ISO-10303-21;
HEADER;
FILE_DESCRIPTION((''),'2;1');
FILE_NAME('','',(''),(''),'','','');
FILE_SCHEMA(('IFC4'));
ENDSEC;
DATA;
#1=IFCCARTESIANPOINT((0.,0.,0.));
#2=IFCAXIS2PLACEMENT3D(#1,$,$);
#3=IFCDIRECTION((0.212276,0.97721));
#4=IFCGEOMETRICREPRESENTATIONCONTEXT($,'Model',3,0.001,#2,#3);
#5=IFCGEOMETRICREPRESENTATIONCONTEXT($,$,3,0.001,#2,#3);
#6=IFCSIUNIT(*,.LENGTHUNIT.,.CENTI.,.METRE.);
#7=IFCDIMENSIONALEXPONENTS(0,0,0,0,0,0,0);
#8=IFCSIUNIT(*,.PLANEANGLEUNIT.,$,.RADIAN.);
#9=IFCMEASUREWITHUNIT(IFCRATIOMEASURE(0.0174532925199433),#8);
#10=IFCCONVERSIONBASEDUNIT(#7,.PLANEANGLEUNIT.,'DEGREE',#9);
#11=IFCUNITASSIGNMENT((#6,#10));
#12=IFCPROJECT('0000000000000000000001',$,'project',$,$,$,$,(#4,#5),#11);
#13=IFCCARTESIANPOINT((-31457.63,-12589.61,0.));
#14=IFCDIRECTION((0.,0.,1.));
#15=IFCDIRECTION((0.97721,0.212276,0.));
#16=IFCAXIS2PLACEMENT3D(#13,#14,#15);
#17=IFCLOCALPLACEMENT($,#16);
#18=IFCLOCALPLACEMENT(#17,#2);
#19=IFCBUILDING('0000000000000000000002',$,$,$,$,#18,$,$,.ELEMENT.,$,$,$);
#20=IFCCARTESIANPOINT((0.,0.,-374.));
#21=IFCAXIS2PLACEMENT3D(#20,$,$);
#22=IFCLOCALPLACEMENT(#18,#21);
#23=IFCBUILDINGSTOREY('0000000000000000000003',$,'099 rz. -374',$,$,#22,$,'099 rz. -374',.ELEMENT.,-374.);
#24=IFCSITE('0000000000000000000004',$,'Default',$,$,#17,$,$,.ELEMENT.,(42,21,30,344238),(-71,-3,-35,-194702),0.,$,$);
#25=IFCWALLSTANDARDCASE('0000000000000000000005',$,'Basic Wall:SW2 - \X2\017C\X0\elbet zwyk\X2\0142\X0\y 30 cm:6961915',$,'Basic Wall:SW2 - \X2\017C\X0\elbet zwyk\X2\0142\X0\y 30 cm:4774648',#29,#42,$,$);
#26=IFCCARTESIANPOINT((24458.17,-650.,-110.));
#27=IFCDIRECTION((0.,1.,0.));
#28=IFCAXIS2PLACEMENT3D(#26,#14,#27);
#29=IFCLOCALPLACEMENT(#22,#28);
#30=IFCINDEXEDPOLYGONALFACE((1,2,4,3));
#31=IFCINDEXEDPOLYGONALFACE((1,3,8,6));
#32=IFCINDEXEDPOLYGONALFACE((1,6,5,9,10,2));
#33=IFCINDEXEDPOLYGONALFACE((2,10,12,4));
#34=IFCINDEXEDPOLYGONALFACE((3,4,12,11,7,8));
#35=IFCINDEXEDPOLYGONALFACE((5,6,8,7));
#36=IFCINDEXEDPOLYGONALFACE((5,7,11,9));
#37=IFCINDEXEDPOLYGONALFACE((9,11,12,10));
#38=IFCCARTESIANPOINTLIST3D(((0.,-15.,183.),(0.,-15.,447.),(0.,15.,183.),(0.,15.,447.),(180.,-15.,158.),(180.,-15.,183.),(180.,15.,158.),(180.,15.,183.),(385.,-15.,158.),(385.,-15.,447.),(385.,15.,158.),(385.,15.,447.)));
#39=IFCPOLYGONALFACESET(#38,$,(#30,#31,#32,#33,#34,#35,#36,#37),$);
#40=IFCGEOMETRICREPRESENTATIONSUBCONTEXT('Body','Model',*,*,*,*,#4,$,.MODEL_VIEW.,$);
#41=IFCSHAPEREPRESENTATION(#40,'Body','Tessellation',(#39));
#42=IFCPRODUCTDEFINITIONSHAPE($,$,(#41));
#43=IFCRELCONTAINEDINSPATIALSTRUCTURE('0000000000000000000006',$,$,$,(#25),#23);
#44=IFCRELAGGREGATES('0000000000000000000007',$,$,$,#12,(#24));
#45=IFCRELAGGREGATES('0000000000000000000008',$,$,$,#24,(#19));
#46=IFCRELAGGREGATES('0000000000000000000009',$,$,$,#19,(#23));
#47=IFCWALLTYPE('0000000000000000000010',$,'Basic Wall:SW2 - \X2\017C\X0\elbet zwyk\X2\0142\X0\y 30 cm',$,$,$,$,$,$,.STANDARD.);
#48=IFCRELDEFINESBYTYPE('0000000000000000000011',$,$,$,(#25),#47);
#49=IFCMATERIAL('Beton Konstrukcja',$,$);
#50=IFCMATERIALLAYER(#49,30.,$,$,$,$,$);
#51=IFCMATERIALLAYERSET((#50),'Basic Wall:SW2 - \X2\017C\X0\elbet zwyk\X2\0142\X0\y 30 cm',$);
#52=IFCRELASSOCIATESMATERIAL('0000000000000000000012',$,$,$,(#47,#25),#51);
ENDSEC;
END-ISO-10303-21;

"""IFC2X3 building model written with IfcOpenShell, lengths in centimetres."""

from ifc_helpers import new_model, entity, si_unit, converted_unit, direction, frame, frame_2d, origin, origin_2d_with_axis, place, context, subcontext, project, spatial, polyline, rectangle, extrude, clip, bounded_halfspace, material, layer, layer_set, layer_usage, type_object, element, save


model = new_model("IFC2X3")

# Units and contexts
model_context = context("Model", 3, precision=0.001, world=origin(), true_north=direction((0.212276, 0.97721)))
context_of_model = context(None, 3, precision=0.001, world=origin(), true_north=direction((0.212276, 0.97721)))
body_context = subcontext(model_context, "Body", "Model", "MODEL_VIEW")
ifc_project = project(units=[si_unit("LENGTHUNIT", "METRE", prefix="CENTI"), converted_unit("PLANEANGLEUNIT", "DEGREE", entity("IfcRatioMeasure", 0.0174532925199433), si_unit("PLANEANGLEUNIT", "RADIAN"), dimensions=[0, 0, 0, 0, 0, 0, 0])], contexts=[model_context, context_of_model])

# Site, building, storey
site_placement = place(None, frame((-31457.63, -12589.61, 0.0), z_axis=(0.0, 0.0, 1.0), x_axis=(0.97721, 0.212276, 0.0)))
site = spatial("IfcSite", under=ifc_project, at=site_placement, Name="Default", CompositionType="ELEMENT", RefLatitude=(42, 21, 30, 344238), RefLongitude=(-71, -3, -35, -194702), RefElevation=0.0)
building_placement = place(site_placement, origin())
building = spatial("IfcBuilding", under=site, at=building_placement, CompositionType="ELEMENT")
storey_placement = place(building_placement, frame((0.0, 0.0, -374.0)))
storey = spatial("IfcBuildingStorey", under=building, at=storey_placement, Name="099 rz. -374", LongName="099 rz. -374", CompositionType="ELEMENT", Elevation=-374.0)

# Shared definitions
ifc_material_1 = material(Name="Beton Konstrukcja")

# Wall, openings
ifc_layer_1 = layer(ifc_material_1, 30.0)
ifc_layer_set_1 = layer_set([ifc_layer_1], Name="Basic Wall:SW2 - żelbet zwykły 30 cm")
ifc_layer_usage_1 = layer_usage(ifc_layer_set_1, "AXIS2", "POSITIVE", -15.0)
wall_type_1 = type_object("IfcWallType", Name="Basic Wall:SW2 - żelbet zwykły 30 cm", PredefinedType="STANDARD", material=ifc_layer_set_1)
wall_1_placement = place(storey_placement, frame((24458.17, -650.0, -110.0), z_axis=(0.0, 0.0, 1.0), x_axis=(0.0, 1.0, 0.0)))
wall_1 = element("IfcWallStandardCase", 1, at=wall_1_placement, inside=storey, type_object=wall_type_1, material=ifc_layer_usage_1, Name="Basic Wall:SW2 - żelbet zwykły 30 cm:6961915", ObjectType="Basic Wall:SW2 - żelbet zwykły 30 cm:4774648", context=body_context, shape_type="Clipping", body=[
    clip(clip(clip(extrude(rectangle(XDim=385.0, YDim=30.0, at=frame_2d((192.5, 0.0), x_axis=(-1.0, 0.0))), origin(), (0.0, 0.0, 1.0), 447.0), bounded_halfspace(frame((180.0, -15.0, 183.0), z_axis=(0.0, 0.0, 1.0), x_axis=(-1.0, 0.0, 0.0)), True, frame((180.0, -15.0, 183.0)), polyline([(0.0, 0.0), (0.0, 30.0), (-20.0, 30.0), (-180.0, 30.0), (-180.0, 0.0), (0.0, 0.0)]))), bounded_halfspace(frame((0.0, -15.0, 447.0), z_axis=(0.0, 0.0, -1.0), x_axis=(0.0, -1.0, 0.0)), True, frame((0.0, -15.0, 447.0)), polyline([(0.0, 0.0), (385.0, 0.0), (385.0, 30.0), (180.0, 30.0), (0.0, 30.0), (0.0, 0.0)]))), bounded_halfspace(frame((385.0, -15.0, 158.0), z_axis=(0.0, 0.0, 1.0), x_axis=(0.0, 1.0, 0.0)), True, frame((385.0, -15.0, 158.0), z_axis=(0.0, 0.0, 1.0), x_axis=(0.0, 1.0, 0.0)), polyline([(0.0, 0.0), (30.0, 0.0), (30.0, 205.0), (0.0, 205.0), (0.0, 0.0)]))),
])
opening_1_placement = place(wall_1_placement, frame((-1315.0, 15.0, 394.0)))
element("IfcOpeningElement", 2, at=opening_1_placement, cuts=wall_1, ObjectType="Opening", context=body_context, shape_type="SweptSolid", body=[
    extrude(rectangle(XDim=422.0, YDim=110.0, at=origin_2d_with_axis()), frame((55.0, -30.0, 211.0), z_axis=(0.0, 1.0, 0.0), x_axis=(0.0, 0.0, -1.0)), (0.0, 0.0, 1.0), 30.0),
])
opening_2_placement = place(wall_1_placement, frame((-1077.0, 15.0, 394.0)))
element("IfcOpeningElement", 3, at=opening_2_placement, cuts=wall_1, ObjectType="Opening", context=body_context, shape_type="SweptSolid", body=[
    extrude(rectangle(XDim=422.0, YDim=110.0, at=frame_2d((0.0, 0.0), x_axis=(1.0, 0.0))), frame((55.0, -30.0, 211.0), z_axis=(0.0, 1.0, 0.0), x_axis=(0.0, 0.0, -1.0)), (0.0, 0.0, 1.0), 30.0),
])

save(model, "model.ifc")
